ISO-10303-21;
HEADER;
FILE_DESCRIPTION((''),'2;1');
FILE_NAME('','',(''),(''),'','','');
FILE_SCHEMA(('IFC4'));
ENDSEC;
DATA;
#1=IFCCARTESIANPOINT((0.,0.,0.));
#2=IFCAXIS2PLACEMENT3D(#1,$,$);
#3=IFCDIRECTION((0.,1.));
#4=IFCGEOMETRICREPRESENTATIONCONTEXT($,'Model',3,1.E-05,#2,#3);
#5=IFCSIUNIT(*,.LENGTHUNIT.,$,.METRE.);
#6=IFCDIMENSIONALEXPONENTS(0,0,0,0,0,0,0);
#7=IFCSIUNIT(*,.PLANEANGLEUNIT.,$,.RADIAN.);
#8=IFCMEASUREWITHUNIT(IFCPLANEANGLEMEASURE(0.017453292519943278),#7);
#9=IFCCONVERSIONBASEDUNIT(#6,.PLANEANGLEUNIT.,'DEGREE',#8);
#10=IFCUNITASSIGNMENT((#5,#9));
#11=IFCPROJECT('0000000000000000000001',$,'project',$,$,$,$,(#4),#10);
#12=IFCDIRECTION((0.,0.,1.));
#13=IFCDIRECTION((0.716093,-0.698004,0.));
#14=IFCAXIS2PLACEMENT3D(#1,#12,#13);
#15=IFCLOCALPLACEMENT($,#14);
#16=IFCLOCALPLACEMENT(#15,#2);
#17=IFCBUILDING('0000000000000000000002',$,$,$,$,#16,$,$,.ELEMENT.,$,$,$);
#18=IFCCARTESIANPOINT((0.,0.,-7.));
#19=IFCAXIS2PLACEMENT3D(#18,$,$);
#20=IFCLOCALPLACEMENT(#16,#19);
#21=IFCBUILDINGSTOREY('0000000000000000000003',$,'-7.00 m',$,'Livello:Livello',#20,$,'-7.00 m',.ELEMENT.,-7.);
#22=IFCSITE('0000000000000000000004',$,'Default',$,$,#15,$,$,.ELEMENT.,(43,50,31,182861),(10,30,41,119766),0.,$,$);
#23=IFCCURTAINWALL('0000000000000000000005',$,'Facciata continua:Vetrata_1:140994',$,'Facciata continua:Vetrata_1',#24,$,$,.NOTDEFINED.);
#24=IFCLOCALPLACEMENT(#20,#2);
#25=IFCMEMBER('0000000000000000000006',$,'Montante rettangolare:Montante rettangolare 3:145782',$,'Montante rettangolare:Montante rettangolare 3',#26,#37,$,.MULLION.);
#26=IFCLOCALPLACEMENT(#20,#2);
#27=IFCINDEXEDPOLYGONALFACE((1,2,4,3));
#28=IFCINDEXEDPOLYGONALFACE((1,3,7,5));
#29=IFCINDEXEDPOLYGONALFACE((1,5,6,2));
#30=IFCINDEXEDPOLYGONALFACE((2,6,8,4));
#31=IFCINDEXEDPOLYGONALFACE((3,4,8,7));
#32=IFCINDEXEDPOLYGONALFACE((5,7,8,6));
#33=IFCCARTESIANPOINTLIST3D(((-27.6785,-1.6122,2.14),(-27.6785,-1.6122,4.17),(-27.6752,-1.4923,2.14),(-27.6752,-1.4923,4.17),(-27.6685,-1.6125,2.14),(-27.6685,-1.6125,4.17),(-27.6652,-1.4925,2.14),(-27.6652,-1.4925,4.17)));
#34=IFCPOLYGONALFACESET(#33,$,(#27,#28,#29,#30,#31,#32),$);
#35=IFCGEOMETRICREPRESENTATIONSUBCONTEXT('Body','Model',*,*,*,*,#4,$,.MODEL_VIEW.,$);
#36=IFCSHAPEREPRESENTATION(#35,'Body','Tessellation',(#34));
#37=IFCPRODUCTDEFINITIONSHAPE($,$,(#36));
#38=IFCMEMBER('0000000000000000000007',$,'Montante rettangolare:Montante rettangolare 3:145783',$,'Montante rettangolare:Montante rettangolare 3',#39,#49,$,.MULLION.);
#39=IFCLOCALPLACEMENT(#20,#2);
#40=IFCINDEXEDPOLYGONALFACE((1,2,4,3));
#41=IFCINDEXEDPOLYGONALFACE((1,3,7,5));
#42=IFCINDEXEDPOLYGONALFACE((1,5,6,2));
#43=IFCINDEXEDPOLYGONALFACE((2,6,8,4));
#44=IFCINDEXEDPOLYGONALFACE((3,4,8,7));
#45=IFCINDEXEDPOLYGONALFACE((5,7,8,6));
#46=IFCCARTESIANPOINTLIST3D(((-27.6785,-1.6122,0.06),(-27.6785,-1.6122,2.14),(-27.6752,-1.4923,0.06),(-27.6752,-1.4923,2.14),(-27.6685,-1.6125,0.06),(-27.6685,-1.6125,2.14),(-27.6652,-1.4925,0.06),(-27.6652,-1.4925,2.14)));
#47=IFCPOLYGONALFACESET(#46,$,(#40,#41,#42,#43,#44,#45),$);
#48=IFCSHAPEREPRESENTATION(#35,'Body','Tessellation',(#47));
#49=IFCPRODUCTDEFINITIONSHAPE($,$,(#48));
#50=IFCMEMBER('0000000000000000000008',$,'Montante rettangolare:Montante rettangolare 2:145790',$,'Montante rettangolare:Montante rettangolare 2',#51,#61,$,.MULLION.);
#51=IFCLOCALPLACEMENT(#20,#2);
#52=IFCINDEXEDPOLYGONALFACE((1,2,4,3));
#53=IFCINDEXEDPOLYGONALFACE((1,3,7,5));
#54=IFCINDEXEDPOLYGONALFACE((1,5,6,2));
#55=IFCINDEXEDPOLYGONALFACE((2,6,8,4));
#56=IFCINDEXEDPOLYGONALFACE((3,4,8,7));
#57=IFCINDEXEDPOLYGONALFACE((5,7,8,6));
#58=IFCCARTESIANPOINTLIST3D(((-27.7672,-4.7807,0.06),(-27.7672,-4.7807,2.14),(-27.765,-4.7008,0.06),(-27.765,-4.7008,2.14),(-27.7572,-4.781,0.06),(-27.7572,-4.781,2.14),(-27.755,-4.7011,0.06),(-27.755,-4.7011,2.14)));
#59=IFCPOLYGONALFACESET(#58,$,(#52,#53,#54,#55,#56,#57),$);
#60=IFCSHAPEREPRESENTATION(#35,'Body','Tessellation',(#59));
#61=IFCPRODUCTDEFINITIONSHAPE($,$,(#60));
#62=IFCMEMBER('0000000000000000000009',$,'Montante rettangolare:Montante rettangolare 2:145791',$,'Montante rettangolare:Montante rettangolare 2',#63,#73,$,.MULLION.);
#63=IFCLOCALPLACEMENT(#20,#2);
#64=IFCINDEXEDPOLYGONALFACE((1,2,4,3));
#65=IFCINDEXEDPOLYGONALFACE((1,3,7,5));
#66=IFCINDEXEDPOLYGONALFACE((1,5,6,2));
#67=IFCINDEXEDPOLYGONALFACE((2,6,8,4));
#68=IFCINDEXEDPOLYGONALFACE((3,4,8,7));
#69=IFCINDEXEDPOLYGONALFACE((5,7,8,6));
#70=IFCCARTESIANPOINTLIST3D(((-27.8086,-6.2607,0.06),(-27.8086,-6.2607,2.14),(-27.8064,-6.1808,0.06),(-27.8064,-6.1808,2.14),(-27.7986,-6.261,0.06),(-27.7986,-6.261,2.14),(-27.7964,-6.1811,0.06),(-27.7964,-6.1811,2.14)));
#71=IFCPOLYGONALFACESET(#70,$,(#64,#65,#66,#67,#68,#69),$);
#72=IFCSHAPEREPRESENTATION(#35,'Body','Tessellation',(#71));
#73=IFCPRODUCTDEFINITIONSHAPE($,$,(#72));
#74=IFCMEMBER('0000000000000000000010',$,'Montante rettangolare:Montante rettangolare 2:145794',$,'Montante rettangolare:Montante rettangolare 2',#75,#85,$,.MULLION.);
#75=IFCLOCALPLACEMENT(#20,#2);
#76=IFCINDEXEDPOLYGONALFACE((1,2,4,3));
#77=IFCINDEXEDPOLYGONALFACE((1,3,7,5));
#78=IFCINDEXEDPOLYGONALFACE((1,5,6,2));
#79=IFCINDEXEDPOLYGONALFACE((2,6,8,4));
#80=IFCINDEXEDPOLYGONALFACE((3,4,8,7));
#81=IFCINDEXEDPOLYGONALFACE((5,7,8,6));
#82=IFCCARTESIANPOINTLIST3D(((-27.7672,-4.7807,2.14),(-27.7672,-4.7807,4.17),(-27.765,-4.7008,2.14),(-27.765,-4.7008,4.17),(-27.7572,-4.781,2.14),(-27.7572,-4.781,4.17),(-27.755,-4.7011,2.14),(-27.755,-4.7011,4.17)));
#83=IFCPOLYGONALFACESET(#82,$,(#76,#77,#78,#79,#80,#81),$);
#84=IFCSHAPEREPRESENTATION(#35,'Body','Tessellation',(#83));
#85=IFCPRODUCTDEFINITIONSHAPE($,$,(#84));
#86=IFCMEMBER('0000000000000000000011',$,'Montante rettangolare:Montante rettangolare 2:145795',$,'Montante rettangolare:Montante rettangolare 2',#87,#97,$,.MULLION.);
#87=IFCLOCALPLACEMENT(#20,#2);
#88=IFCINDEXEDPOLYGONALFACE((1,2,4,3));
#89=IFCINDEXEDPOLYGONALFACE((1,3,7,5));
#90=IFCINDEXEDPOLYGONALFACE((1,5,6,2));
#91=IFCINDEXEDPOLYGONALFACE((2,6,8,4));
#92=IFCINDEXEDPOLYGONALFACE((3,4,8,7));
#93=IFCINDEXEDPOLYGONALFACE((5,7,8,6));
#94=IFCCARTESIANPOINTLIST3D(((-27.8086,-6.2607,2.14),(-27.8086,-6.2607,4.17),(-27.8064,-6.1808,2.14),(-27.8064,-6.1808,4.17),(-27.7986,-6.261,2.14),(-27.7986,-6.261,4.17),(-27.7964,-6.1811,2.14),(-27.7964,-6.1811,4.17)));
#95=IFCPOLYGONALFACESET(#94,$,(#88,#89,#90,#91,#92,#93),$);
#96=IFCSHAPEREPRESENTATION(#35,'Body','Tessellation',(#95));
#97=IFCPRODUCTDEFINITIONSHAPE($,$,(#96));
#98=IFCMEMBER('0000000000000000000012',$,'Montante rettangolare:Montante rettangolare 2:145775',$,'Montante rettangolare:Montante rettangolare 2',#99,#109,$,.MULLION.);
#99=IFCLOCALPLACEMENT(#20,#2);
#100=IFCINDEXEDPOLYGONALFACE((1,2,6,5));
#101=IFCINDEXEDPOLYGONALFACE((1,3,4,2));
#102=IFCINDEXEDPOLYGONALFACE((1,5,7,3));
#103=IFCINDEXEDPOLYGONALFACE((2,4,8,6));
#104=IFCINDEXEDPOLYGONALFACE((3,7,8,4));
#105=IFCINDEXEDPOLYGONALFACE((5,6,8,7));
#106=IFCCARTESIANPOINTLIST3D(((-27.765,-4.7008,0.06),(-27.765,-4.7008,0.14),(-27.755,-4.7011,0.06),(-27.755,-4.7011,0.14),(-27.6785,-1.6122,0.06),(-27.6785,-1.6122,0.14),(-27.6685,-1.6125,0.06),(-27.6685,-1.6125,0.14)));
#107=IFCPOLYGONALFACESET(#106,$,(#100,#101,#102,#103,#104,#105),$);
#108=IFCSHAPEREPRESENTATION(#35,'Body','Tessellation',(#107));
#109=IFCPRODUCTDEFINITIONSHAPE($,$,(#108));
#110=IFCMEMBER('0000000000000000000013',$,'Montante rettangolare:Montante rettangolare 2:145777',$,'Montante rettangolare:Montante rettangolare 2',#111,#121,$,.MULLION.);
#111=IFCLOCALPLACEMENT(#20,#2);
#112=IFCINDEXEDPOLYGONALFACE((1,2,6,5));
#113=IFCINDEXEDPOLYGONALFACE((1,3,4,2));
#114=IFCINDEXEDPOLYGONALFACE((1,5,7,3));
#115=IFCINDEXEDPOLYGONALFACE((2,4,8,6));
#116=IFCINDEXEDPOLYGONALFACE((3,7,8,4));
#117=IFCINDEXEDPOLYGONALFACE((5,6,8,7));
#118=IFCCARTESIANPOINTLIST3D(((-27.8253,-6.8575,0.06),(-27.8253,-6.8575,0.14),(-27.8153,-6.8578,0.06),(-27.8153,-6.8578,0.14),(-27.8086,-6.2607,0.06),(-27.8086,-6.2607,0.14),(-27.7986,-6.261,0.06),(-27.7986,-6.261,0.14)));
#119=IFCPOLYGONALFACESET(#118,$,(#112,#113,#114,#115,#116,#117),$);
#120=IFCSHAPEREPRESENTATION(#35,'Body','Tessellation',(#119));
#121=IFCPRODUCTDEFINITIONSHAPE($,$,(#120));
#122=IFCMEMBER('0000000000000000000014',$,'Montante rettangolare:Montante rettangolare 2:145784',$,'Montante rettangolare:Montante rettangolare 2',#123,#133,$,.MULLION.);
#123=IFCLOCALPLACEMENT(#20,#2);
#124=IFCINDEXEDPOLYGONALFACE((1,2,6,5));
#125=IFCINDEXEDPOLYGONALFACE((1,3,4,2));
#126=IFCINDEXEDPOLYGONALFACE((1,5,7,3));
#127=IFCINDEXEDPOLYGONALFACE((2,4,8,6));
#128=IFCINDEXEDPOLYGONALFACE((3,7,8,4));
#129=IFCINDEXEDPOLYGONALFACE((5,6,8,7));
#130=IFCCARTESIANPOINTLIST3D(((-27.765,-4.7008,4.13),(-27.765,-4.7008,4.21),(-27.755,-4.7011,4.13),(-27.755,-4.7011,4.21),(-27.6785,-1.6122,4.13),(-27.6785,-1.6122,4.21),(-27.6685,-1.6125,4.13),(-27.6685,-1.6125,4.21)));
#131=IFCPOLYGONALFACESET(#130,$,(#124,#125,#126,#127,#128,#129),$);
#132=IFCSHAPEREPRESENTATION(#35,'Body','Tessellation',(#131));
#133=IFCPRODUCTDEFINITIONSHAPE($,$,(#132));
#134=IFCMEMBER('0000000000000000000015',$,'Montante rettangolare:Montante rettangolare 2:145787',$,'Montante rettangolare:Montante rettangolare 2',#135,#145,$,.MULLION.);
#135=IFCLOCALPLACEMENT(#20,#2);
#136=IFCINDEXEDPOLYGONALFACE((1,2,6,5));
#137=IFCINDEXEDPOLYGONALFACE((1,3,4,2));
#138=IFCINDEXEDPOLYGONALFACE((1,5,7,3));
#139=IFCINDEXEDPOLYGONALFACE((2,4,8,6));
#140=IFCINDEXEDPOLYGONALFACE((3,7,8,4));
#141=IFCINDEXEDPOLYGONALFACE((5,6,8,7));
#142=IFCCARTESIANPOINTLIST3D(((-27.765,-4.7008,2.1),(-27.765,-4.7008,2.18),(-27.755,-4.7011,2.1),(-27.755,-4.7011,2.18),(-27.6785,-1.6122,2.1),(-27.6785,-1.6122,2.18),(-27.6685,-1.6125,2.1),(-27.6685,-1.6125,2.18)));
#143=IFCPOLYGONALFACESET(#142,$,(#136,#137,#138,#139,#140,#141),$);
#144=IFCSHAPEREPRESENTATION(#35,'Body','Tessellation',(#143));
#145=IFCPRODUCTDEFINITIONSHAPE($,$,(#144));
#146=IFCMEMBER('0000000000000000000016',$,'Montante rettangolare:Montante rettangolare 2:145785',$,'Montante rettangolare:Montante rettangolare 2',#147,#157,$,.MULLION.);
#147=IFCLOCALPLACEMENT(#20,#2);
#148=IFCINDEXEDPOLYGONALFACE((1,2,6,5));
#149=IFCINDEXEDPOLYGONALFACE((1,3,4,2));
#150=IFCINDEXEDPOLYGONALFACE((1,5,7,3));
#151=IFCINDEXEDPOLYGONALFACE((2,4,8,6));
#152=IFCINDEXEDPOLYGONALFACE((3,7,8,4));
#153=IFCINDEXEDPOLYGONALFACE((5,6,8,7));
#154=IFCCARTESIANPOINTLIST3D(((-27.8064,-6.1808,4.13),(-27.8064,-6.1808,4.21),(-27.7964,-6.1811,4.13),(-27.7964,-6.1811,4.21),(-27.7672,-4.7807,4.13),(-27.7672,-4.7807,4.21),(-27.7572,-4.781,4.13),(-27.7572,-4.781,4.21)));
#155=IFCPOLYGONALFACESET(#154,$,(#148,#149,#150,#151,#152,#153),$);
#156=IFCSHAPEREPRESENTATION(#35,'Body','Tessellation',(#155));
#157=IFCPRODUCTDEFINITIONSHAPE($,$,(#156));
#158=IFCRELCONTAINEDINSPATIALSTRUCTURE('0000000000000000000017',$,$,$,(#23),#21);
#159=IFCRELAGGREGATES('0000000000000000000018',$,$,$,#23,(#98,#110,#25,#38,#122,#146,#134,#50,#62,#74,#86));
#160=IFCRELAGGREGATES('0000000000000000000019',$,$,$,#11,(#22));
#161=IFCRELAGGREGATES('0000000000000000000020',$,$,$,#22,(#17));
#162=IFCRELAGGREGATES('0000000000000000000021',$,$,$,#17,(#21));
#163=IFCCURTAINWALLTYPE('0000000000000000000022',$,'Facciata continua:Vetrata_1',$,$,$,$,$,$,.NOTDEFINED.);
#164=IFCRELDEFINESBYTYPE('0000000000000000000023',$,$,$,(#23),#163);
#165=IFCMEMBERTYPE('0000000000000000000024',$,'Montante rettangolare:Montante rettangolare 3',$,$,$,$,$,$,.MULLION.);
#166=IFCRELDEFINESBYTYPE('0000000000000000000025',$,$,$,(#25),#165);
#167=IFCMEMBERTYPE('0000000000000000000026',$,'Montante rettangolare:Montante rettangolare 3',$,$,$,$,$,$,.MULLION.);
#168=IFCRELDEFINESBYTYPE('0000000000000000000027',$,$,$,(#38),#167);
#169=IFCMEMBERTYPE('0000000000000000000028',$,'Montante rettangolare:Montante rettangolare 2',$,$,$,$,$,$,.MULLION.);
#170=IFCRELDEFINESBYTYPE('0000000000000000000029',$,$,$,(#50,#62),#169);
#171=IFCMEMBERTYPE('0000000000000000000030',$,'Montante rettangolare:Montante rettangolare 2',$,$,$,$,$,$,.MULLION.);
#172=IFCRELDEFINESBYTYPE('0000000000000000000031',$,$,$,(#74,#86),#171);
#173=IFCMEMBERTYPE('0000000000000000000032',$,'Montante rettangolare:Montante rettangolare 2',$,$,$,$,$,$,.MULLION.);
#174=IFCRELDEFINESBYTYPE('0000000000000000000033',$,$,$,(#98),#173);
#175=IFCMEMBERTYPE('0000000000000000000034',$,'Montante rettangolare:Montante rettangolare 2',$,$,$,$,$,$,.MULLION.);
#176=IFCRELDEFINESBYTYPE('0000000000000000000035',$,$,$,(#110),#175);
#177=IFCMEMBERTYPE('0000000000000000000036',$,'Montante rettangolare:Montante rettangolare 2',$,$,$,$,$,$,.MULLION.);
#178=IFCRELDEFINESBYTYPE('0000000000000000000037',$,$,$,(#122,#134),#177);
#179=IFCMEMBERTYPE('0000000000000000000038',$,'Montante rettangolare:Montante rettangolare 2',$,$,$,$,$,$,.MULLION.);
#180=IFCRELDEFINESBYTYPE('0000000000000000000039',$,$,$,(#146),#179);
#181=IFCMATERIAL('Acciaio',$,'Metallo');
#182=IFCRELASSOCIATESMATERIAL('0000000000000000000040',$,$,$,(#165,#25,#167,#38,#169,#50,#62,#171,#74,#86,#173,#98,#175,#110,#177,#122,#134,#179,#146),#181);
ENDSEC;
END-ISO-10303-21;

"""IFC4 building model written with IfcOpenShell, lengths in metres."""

from ifc_helpers import new_model, entity, si_unit, converted_unit, direction, frame, origin, place, context, subcontext, project, spatial, indexed_curve, outline, extrude, source, transform, mapped, material, type_object, type_shapes, element, aggregate, save


model = new_model("IFC4")

# Units and contexts
model_context = context("Model", 3, precision=1e-05, world=origin(), true_north=direction((0.0, 1.0)))
body_context = subcontext(model_context, "Body", "Model", "MODEL_VIEW")
ifc_project = project(units=[si_unit("LENGTHUNIT", "METRE"), converted_unit("PLANEANGLEUNIT", "DEGREE", entity("IfcPlaneAngleMeasure", 0.017453292519943278), si_unit("PLANEANGLEUNIT", "RADIAN"), dimensions=[0, 0, 0, 0, 0, 0, 0])], contexts=[model_context])

# Site, building, storey
site_placement = place(None, frame((0.0, 0.0, 0.0), z_axis=(0.0, 0.0, 1.0), x_axis=(0.716093, -0.698004, 0.0)))
site = spatial("IfcSite", under=ifc_project, at=site_placement, Name="Default", CompositionType="ELEMENT", RefLatitude=(43, 50, 31, 182861), RefLongitude=(10, 30, 41, 119766), RefElevation=0.0)
building_placement = place(site_placement, origin())
building = spatial("IfcBuilding", under=site, at=building_placement, CompositionType="ELEMENT")
storey_placement = place(building_placement, frame((0.0, 0.0, -7.0)))
storey = spatial("IfcBuildingStorey", under=building, at=storey_placement, Name="-7.00 m", ObjectType="Livello:Livello", LongName="-7.00 m", CompositionType="ELEMENT", Elevation=-7.0)

# Curtain wall, members
curtain_wall_type = type_object("IfcCurtainWallType", Name="Facciata continua:Vetrata_1", PredefinedType="NOTDEFINED")
curtain_wall_placement = place(storey_placement, frame((0.0, 0.0, 7.0)))
curtain_wall = element("IfcCurtainWall", 1, at=curtain_wall_placement, inside=storey, type_object=curtain_wall_type, Name="Facciata continua:Vetrata_1:140994", ObjectType="Facciata continua:Vetrata_1", PredefinedType="NOTDEFINED")
ifc_material_1 = material(Name="Acciaio", Category="Metallo")
member_type_1 = type_object("IfcMemberType", Name="Montante rettangolare:Montante rettangolare 3", PredefinedType="MULLION", material=ifc_material_1)
shared_shape_1 = source(origin(), body_context, "Body", "SweptSolid", [
    extrude(outline(indexed_curve([(-0.06, -0.005), (0.06, -0.005), (0.06, 0.005), (-0.06, 0.005), (-0.06, -0.005)], self_intersect=False)), frame((-0.06, 0.01, -2.03), z_axis=(0.0, 0.0, 1.0), x_axis=(-1.0, 0.0, 0.0)), (0.0, 0.0, 1.0), 2.03),
])
type_shapes(member_type_1, [shared_shape_1])
member_1_placement = place(curtain_wall_placement, frame((-27.6602, -1.4927, -2.83), z_axis=(0.0, 0.0, 1.0), x_axis=(0.02798, 0.999608, 0.0)))
member_1 = element("IfcMember", 2, at=member_1_placement, type_object=member_type_1, material=ifc_material_1, Name="Montante rettangolare:Montante rettangolare 3:145782", ObjectType="Montante rettangolare:Montante rettangolare 3", PredefinedType="MULLION", context=body_context, shape_type="MappedRepresentation", body=[
    mapped(shared_shape_1, transform((0.0, 0.0, 0.0), scale=1.0)),
])
member_type_2 = type_object("IfcMemberType", Name="Montante rettangolare:Montante rettangolare 3", PredefinedType="MULLION", material=ifc_material_1)
shared_shape_2 = source(origin(), body_context, "Body", "SweptSolid", [
    extrude(outline(indexed_curve([(-0.06, -0.005), (0.06, -0.005), (0.06, 0.005), (-0.06, 0.005), (-0.06, -0.005)], self_intersect=False)), frame((-0.06, 0.01, -2.08), z_axis=(0.0, 0.0, 1.0), x_axis=(-1.0, 0.0, 0.0)), (0.0, 0.0, 1.0), 2.08),
])
type_shapes(member_type_2, [shared_shape_2])
member_2_placement = place(curtain_wall_placement, frame((-27.6602, -1.4927, -4.86), z_axis=(0.0, 0.0, 1.0), x_axis=(0.02798, 0.999608, 0.0)))
member_2 = element("IfcMember", 3, at=member_2_placement, type_object=member_type_2, material=ifc_material_1, Name="Montante rettangolare:Montante rettangolare 3:145783", ObjectType="Montante rettangolare:Montante rettangolare 3", PredefinedType="MULLION", context=body_context, shape_type="MappedRepresentation", body=[
    mapped(shared_shape_2, transform((0.0, 0.0, 0.0), scale=1.0)),
])
member_type_3 = type_object("IfcMemberType", Name="Montante rettangolare:Montante rettangolare 2", PredefinedType="MULLION", material=ifc_material_1)
shared_shape_3 = source(origin(), body_context, "Body", "SweptSolid", [
    extrude(outline(indexed_curve([(-0.04, -0.005), (0.04, -0.005), (0.04, 0.005), (-0.04, 0.005), (-0.04, -0.005)], self_intersect=False)), frame((0.0, 0.01, -2.08), z_axis=(0.0, 0.0, 1.0), x_axis=(-1.0, 0.0, 0.0)), (0.0, 0.0, 1.0), 2.08),
])
type_shapes(member_type_3, [shared_shape_3])
member_3_placement = place(curtain_wall_placement, frame((-27.7511, -4.7412, -6.94), z_axis=(0.0, 0.0, -1.0), x_axis=(-0.02798, -0.999608, 0.0)))
member_3 = element("IfcMember", 4, at=member_3_placement, type_object=member_type_3, material=ifc_material_1, Name="Montante rettangolare:Montante rettangolare 2:145790", ObjectType="Montante rettangolare:Montante rettangolare 2", PredefinedType="MULLION", context=body_context, shape_type="MappedRepresentation", body=[
    mapped(shared_shape_3, transform((0.0, 0.0, 0.0), scale=1.0)),
])
member_4_placement = place(curtain_wall_placement, frame((-27.7925, -6.2212, -6.94), z_axis=(0.0, 0.0, -1.0), x_axis=(-0.02798, -0.999608, 0.0)))
member_4 = element("IfcMember", 5, at=member_4_placement, type_object=member_type_3, material=ifc_material_1, Name="Montante rettangolare:Montante rettangolare 2:145791", ObjectType="Montante rettangolare:Montante rettangolare 2", PredefinedType="MULLION", context=body_context, shape_type="MappedRepresentation", body=[
    mapped(shared_shape_3, transform((0.0, 0.0, 0.0), scale=1.0)),
])
member_type_4 = type_object("IfcMemberType", Name="Montante rettangolare:Montante rettangolare 2", PredefinedType="MULLION", material=ifc_material_1)
shared_shape_4 = source(origin(), body_context, "Body", "SweptSolid", [
    extrude(outline(indexed_curve([(-0.04, -0.005), (0.04, -0.005), (0.04, 0.005), (-0.04, 0.005), (-0.04, -0.005)], self_intersect=False)), frame((0.0, 0.01, -2.03), z_axis=(0.0, 0.0, 1.0), x_axis=(-1.0, 0.0, 0.0)), (0.0, 0.0, 1.0), 2.03),
])
type_shapes(member_type_4, [shared_shape_4])
member_5_placement = place(curtain_wall_placement, frame((-27.7511, -4.7412, -4.86), z_axis=(0.0, 0.0, -1.0), x_axis=(-0.02798, -0.999608, 0.0)))
member_5 = element("IfcMember", 6, at=member_5_placement, type_object=member_type_4, material=ifc_material_1, Name="Montante rettangolare:Montante rettangolare 2:145794", ObjectType="Montante rettangolare:Montante rettangolare 2", PredefinedType="MULLION", context=body_context, shape_type="MappedRepresentation", body=[
    mapped(shared_shape_4, transform((0.0, 0.0, 0.0), scale=1.0)),
])
member_6_placement = place(curtain_wall_placement, frame((-27.7925, -6.2212, -4.86), z_axis=(0.0, 0.0, -1.0), x_axis=(-0.02798, -0.999608, 0.0)))
member_6 = element("IfcMember", 7, at=member_6_placement, type_object=member_type_4, material=ifc_material_1, Name="Montante rettangolare:Montante rettangolare 2:145795", ObjectType="Montante rettangolare:Montante rettangolare 2", PredefinedType="MULLION", context=body_context, shape_type="MappedRepresentation", body=[
    mapped(shared_shape_4, transform((0.0, 0.0, 0.0), scale=1.0)),
])
member_type_5 = type_object("IfcMemberType", Name="Montante rettangolare:Montante rettangolare 2", PredefinedType="MULLION", material=ifc_material_1)
shared_shape_5 = source(origin(), body_context, "Body", "SweptSolid", [
    extrude(outline(indexed_curve([(-0.04, -0.005), (0.04, -0.005), (0.04, 0.005), (-0.04, 0.005), (-0.04, -0.005)], self_intersect=False)), frame((-0.04, 0.01, -3.0898), z_axis=(0.0, 0.0, 1.0), x_axis=(-1.0, 0.0, 0.0)), (0.0, 0.0, 1.0), 3.0898),
])
type_shapes(member_type_5, [shared_shape_5])
member_7_placement = place(curtain_wall_placement, frame((-27.6635, -1.6126, -6.94), z_axis=(0.02798, 0.999608, 0.0), x_axis=(0.0, 0.0, -1.0)))
member_7 = element("IfcMember", 8, at=member_7_placement, type_object=member_type_5, material=ifc_material_1, Name="Montante rettangolare:Montante rettangolare 2:145775", ObjectType="Montante rettangolare:Montante rettangolare 2", PredefinedType="MULLION", context=body_context, shape_type="MappedRepresentation", body=[
    mapped(shared_shape_5, transform((0.0, 0.0, 0.0), scale=1.0)),
])
member_type_6 = type_object("IfcMemberType", Name="Montante rettangolare:Montante rettangolare 2", PredefinedType="MULLION", material=ifc_material_1)
shared_shape_6 = source(origin(), body_context, "Body", "SweptSolid", [
    extrude(outline(indexed_curve([(-0.04, -0.005), (0.04, -0.005), (0.04, 0.005), (-0.04, 0.005), (-0.04, -0.005)], self_intersect=False)), frame((-0.04, 0.01, -0.597), z_axis=(0.0, 0.0, 1.0), x_axis=(-1.0, 0.0, 0.0)), (0.0, 0.0, 1.0), 0.597),
])
type_shapes(member_type_6, [shared_shape_6])
member_8_placement = place(curtain_wall_placement, frame((-27.7936, -6.2612, -6.94), z_axis=(0.02798, 0.999608, 0.0), x_axis=(0.0, 0.0, -1.0)))
member_8 = element("IfcMember", 9, at=member_8_placement, type_object=member_type_6, material=ifc_material_1, Name="Montante rettangolare:Montante rettangolare 2:145777", ObjectType="Montante rettangolare:Montante rettangolare 2", PredefinedType="MULLION", context=body_context, shape_type="MappedRepresentation", body=[
    mapped(shared_shape_6, transform((0.0, 0.0, 0.0), scale=1.0)),
])
member_type_7 = type_object("IfcMemberType", Name="Montante rettangolare:Montante rettangolare 2", PredefinedType="MULLION", material=ifc_material_1)
shared_shape_7 = source(origin(), body_context, "Body", "SweptSolid", [
    extrude(outline(indexed_curve([(-0.04, -0.005), (0.04, -0.005), (0.04, 0.005), (-0.04, 0.005), (-0.04, -0.005)], self_intersect=False)), frame((0.0, 0.01, -3.0898), z_axis=(0.0, 0.0, 1.0), x_axis=(-1.0, 0.0, 0.0)), (0.0, 0.0, 1.0), 3.0898),
])
type_shapes(member_type_7, [shared_shape_7])
member_9_placement = place(curtain_wall_placement, frame((-27.75, -4.7012, -2.83), z_axis=(-0.02798, -0.999608, 0.0), x_axis=(0.0, 0.0, 1.0)))
member_9 = element("IfcMember", 10, at=member_9_placement, type_object=member_type_7, material=ifc_material_1, Name="Montante rettangolare:Montante rettangolare 2:145784", ObjectType="Montante rettangolare:Montante rettangolare 2", PredefinedType="MULLION", context=body_context, shape_type="MappedRepresentation", body=[
    mapped(shared_shape_7, transform((0.0, 0.0, 0.0), scale=1.0)),
])
member_10_placement = place(curtain_wall_placement, frame((-27.75, -4.7012, -4.86), z_axis=(-0.02798, -0.999608, 0.0), x_axis=(0.0, 0.0, 1.0)))
member_10 = element("IfcMember", 11, at=member_10_placement, type_object=member_type_7, material=ifc_material_1, Name="Montante rettangolare:Montante rettangolare 2:145787", ObjectType="Montante rettangolare:Montante rettangolare 2", PredefinedType="MULLION", context=body_context, shape_type="MappedRepresentation", body=[
    mapped(shared_shape_7, transform((0.0, 0.0, 0.0), scale=1.0)),
])
member_type_8 = type_object("IfcMemberType", Name="Montante rettangolare:Montante rettangolare 2", PredefinedType="MULLION", material=ifc_material_1)
shared_shape_8 = source(origin(), body_context, "Body", "SweptSolid", [
    extrude(outline(indexed_curve([(-0.04, -0.005), (0.04, -0.005), (0.04, 0.005), (-0.04, 0.005), (-0.04, -0.005)], self_intersect=False)), frame((0.0, 0.01, -1.4006), z_axis=(0.0, 0.0, 1.0), x_axis=(-1.0, 0.0, 0.0)), (0.0, 0.0, 1.0), 1.4006),
])
type_shapes(member_type_8, [shared_shape_8])
member_11_placement = place(curtain_wall_placement, frame((-27.7914, -6.1812, -2.83), z_axis=(-0.02798, -0.999608, 0.0), x_axis=(0.0, 0.0, 1.0)))
member_11 = element("IfcMember", 12, at=member_11_placement, type_object=member_type_8, material=ifc_material_1, Name="Montante rettangolare:Montante rettangolare 2:145785", ObjectType="Montante rettangolare:Montante rettangolare 2", PredefinedType="MULLION", context=body_context, shape_type="MappedRepresentation", body=[
    mapped(shared_shape_8, transform((0.0, 0.0, 0.0), scale=1.0)),
])
aggregate(curtain_wall, [member_7, member_8, member_1, member_2, member_9, member_11, member_10, member_3, member_4, member_5, member_6])

save(model, "model.ifc")
